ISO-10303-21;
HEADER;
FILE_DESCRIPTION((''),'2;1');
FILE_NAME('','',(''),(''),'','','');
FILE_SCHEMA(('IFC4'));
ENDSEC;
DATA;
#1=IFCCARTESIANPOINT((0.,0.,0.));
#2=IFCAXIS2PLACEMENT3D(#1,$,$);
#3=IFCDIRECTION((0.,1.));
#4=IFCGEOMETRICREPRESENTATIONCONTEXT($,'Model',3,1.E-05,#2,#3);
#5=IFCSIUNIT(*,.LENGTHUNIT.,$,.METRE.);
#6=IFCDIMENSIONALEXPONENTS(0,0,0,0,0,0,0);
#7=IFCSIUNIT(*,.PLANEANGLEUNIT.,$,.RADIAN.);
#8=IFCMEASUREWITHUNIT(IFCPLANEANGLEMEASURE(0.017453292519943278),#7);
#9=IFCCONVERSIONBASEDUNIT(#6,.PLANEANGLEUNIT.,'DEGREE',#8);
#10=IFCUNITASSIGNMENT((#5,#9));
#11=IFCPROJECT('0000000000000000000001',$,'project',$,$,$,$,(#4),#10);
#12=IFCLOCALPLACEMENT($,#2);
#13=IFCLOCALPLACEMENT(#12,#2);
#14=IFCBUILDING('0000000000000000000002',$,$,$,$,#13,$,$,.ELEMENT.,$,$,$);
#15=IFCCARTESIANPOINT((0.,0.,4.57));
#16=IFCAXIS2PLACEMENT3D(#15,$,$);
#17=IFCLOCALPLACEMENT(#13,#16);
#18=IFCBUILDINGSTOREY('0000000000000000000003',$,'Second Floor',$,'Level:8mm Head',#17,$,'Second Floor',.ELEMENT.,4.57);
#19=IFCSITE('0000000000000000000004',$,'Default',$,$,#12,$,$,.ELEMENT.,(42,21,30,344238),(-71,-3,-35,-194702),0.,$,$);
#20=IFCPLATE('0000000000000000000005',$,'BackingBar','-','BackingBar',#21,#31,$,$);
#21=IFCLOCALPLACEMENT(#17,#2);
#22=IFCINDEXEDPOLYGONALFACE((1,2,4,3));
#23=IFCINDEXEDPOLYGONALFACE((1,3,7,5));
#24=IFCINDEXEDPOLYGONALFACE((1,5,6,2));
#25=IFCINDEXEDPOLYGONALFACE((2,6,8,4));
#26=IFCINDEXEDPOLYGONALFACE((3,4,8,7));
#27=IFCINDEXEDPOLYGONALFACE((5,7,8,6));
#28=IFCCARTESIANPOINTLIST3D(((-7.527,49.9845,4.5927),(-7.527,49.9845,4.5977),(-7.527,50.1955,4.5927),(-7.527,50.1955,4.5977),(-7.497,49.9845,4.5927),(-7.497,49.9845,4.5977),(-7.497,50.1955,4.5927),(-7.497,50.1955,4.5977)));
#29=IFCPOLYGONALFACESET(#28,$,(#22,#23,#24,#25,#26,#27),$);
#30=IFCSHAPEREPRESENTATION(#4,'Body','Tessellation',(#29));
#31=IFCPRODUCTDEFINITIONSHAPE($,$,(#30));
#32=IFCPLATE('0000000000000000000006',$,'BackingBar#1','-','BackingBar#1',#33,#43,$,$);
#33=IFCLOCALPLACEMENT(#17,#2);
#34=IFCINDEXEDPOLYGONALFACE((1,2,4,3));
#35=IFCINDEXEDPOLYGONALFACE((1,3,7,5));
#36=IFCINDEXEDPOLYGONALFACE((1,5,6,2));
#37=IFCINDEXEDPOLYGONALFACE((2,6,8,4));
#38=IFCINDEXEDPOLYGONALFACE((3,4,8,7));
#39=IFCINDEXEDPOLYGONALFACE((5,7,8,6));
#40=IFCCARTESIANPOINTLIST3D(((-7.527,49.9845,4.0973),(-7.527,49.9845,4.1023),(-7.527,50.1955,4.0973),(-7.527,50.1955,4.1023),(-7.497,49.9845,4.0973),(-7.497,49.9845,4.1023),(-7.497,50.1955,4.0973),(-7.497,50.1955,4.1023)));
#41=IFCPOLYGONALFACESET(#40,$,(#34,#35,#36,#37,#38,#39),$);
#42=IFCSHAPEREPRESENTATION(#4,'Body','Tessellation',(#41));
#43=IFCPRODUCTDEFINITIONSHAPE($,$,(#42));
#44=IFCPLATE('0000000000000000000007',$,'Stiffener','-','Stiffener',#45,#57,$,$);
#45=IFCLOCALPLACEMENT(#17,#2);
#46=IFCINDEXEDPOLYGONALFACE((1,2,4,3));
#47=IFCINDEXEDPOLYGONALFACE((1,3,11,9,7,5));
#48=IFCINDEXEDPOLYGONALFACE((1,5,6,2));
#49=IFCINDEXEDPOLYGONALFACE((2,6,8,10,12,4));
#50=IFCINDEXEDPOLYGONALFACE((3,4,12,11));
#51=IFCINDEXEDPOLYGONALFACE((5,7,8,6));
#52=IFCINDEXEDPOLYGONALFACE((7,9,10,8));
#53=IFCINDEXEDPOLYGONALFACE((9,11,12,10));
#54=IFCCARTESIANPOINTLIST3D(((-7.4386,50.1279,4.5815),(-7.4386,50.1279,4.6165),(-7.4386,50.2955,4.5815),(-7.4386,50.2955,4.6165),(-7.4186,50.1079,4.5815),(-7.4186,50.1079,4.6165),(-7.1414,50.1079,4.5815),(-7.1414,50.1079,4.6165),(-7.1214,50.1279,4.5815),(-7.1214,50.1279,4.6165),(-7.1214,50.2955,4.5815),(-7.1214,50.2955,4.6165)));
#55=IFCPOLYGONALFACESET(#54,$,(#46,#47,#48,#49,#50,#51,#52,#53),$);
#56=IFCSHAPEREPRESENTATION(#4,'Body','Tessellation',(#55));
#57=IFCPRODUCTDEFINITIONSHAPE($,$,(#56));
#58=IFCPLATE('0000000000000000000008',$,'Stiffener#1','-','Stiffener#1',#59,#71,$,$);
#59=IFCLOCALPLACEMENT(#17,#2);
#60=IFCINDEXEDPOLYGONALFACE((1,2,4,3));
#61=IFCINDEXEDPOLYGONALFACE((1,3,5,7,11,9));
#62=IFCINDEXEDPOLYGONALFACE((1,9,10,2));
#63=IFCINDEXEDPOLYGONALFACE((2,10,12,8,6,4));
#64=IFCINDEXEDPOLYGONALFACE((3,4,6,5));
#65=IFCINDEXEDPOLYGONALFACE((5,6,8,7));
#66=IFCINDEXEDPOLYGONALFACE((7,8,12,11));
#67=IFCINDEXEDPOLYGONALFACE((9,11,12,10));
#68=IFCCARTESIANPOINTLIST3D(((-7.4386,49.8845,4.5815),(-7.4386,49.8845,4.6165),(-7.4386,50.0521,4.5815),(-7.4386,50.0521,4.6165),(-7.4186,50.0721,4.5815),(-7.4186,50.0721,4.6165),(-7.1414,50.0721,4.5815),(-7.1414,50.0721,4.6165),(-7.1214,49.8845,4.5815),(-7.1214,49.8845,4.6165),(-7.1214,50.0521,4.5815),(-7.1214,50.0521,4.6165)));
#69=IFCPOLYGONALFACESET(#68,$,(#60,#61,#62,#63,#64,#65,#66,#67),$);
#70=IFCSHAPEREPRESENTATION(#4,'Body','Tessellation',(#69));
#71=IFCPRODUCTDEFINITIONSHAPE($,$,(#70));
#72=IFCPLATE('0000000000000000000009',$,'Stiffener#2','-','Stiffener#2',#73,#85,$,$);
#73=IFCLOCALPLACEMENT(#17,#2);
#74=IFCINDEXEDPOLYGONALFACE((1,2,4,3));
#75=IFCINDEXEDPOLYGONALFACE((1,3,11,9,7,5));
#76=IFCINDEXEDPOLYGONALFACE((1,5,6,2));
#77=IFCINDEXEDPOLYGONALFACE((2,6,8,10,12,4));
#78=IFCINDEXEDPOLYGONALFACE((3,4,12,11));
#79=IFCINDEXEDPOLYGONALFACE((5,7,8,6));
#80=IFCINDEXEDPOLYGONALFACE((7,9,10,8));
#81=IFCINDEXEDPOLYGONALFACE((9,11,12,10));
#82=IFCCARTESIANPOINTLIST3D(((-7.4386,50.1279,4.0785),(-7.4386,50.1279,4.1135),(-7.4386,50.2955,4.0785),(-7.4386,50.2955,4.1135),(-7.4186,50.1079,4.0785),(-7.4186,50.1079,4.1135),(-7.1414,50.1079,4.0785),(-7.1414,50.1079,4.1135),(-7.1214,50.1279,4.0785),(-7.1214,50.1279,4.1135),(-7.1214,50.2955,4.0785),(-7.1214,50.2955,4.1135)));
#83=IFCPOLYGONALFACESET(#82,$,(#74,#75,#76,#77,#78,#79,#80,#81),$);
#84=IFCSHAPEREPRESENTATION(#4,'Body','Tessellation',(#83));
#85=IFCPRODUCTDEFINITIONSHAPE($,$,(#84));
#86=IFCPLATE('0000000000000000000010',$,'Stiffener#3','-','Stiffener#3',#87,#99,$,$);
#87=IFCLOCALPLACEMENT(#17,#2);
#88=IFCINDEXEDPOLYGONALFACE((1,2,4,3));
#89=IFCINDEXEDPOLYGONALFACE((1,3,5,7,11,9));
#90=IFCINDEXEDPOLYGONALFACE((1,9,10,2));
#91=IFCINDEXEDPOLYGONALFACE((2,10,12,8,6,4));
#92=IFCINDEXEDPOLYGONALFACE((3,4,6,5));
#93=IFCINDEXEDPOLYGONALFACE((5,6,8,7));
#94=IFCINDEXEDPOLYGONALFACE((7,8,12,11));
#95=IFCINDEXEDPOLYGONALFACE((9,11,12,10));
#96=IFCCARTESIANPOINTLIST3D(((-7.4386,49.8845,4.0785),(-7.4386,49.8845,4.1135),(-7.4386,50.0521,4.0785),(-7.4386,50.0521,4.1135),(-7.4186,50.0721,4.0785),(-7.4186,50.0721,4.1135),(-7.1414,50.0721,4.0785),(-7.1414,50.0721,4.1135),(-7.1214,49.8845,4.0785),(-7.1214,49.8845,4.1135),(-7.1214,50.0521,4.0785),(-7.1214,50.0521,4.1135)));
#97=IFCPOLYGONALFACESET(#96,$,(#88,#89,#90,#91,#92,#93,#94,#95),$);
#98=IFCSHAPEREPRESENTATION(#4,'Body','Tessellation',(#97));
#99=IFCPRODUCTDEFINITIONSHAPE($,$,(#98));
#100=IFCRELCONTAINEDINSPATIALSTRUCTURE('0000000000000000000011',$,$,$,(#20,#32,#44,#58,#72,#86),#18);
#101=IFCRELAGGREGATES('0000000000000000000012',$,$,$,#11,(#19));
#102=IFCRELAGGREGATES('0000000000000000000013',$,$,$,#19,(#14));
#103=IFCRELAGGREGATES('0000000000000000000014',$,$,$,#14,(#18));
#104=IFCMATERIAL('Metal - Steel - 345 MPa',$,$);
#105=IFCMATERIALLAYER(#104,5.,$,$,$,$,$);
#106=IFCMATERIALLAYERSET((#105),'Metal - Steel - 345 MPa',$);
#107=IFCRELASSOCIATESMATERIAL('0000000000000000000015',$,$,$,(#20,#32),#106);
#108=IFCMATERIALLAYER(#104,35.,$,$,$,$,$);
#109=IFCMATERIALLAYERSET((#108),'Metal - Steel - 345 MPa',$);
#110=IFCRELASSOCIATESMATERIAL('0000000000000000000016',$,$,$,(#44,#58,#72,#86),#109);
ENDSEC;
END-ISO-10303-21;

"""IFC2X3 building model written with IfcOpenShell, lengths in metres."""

from ifc_helpers import new_model, entity, si_unit, converted_unit, direction, frame, origin, origin_with_axes, place, context, project, spatial, polyline, outline, extrude, material, layer, layer_set, element, save


model = new_model("IFC2X3")

# Units and contexts
model_context = context("Model", 3, precision=1e-05, world=origin(), true_north=direction((0.0, 1.0)))
ifc_project = project(units=[si_unit("LENGTHUNIT", "METRE"), converted_unit("PLANEANGLEUNIT", "DEGREE", entity("IfcPlaneAngleMeasure", 0.017453292519943278), si_unit("PLANEANGLEUNIT", "RADIAN"), dimensions=[0, 0, 0, 0, 0, 0, 0])], contexts=[model_context])

# Site, building, storey
site_placement = place(None, origin())
site = spatial("IfcSite", under=ifc_project, at=site_placement, Name="Default", CompositionType="ELEMENT", RefLatitude=(42, 21, 30, 344238), RefLongitude=(-71, -3, -35, -194702), RefElevation=0.0)
building_placement = place(site_placement, origin())
building = spatial("IfcBuilding", under=site, at=building_placement, CompositionType="ELEMENT")
storey_placement = place(building_placement, frame((0.0, 0.0, 4.57)))
storey = spatial("IfcBuildingStorey", under=building, at=storey_placement, Name="Second Floor", ObjectType="Level:8mm Head", LongName="Second Floor", CompositionType="ELEMENT", Elevation=4.57)

# Plates
ifc_material_1 = material(Name="Metal - Steel - 345 MPa")
ifc_layer_1 = layer(ifc_material_1, 5.0)
ifc_layer_set_1 = layer_set([ifc_layer_1], Name="Metal - Steel - 345 MPa")
plate_1_placement = place(storey_placement, frame((-7.497, 49.9845, 4.5927), z_axis=(0.0, 0.0, 1.0), x_axis=(0.0, 1.0, 0.0)))
element("IfcPlate", 1, at=plate_1_placement, inside=storey, material=ifc_layer_set_1, Name="BackingBar", Description="-", ObjectType="BackingBar", context=model_context, shape_type="SweptSolid", body=[
    extrude(outline(polyline([(0.0, 0.0), (0.211, 0.0), (0.211, 0.03), (0.0, 0.03), (0.0, 0.0)])), origin_with_axes(), (0.0, 0.0, 1.0), 0.005),
])
plate_2_placement = place(storey_placement, frame((-7.497, 50.1955, 4.1023), z_axis=(0.0, 0.0, -1.0), x_axis=(0.0, -1.0, 0.0)))
element("IfcPlate", 2, at=plate_2_placement, inside=storey, material=ifc_layer_set_1, Name="BackingBar#1", Description="-", ObjectType="BackingBar#1", context=model_context, shape_type="SweptSolid", body=[
    extrude(outline(polyline([(0.0, 0.0), (0.211, 0.0), (0.211, 0.03), (0.0, 0.03), (0.0, 0.0)])), origin_with_axes(), (0.0, 0.0, 1.0), 0.005),
])

# Plates, openings
ifc_layer_2 = layer(ifc_material_1, 35.0)
ifc_layer_set_2 = layer_set([ifc_layer_2], Name="Metal - Steel - 345 MPa")
plate_3_placement = place(storey_placement, frame((-7.4386, 50.2955, 4.5815), z_axis=(0.0, 0.0, 1.0), x_axis=(0.0, -1.0, 0.0)))
plate_3 = element("IfcPlate", 3, at=plate_3_placement, inside=storey, material=ifc_layer_set_2, Name="Stiffener", Description="-", ObjectType="Stiffener", context=model_context, shape_type="SweptSolid", body=[
    extrude(outline(polyline([(0.0, 0.0), (0.1876, 0.0), (0.1876, 0.3172), (0.0, 0.3172), (0.0, 0.0)])), origin_with_axes(), (0.0, 0.0, 1.0), 0.035),
])
opening_1_placement = place(plate_3_placement, frame((0.0, 0.0, 0.0), z_axis=(0.0, 0.0, 1.0), x_axis=(1.0, 0.0, 0.0)))
element("IfcOpeningElement", 4, at=opening_1_placement, cuts=plate_3, ObjectType="Opening", context=model_context, shape_type="SweptSolid", body=[
    extrude(outline(polyline([(0.1876, 0.3172), (0.1676, 0.3172), (0.1876, 0.2972), (0.1876, 0.3172)])), origin(), (0.0, 0.0, 1.0), 0.035),
])
opening_2_placement = place(plate_3_placement, frame((0.0, 0.0, 0.0), z_axis=(0.0, 0.0, 1.0), x_axis=(1.0, 0.0, 0.0)))
element("IfcOpeningElement", 5, at=opening_2_placement, cuts=plate_3, ObjectType="Opening", context=model_context, shape_type="SweptSolid", body=[
    extrude(outline(polyline([(0.1876, 0.0), (0.1876, 0.02), (0.1676, 0.0), (0.1876, 0.0)])), origin(), (0.0, 0.0, 1.0), 0.035),
])
plate_4_placement = place(storey_placement, frame((-7.4386, 50.0721, 4.5815), z_axis=(0.0, 0.0, 1.0), x_axis=(0.0, -1.0, 0.0)))
plate_4 = element("IfcPlate", 6, at=plate_4_placement, inside=storey, material=ifc_layer_set_2, Name="Stiffener#1", Description="-", ObjectType="Stiffener#1", context=model_context, shape_type="SweptSolid", body=[
    extrude(outline(polyline([(0.0, 0.0), (0.1876, 0.0), (0.1876, 0.3172), (0.0, 0.3172), (0.0, 0.0)])), origin_with_axes(), (0.0, 0.0, 1.0), 0.035),
])
opening_3_placement = place(plate_4_placement, frame((0.0, 0.0, 0.0), z_axis=(0.0, 0.0, 1.0), x_axis=(1.0, 0.0, 0.0)))
element("IfcOpeningElement", 7, at=opening_3_placement, cuts=plate_4, ObjectType="Opening", context=model_context, shape_type="SweptSolid", body=[
    extrude(outline(polyline([(0.0, 0.3172), (0.0, 0.2972), (0.02, 0.3172), (0.0, 0.3172)])), origin(), (0.0, 0.0, 1.0), 0.035),
])
opening_4_placement = place(plate_4_placement, frame((0.0, 0.0, 0.0), z_axis=(0.0, 0.0, 1.0), x_axis=(1.0, 0.0, 0.0)))
element("IfcOpeningElement", 8, at=opening_4_placement, cuts=plate_4, ObjectType="Opening", context=model_context, shape_type="SweptSolid", body=[
    extrude(outline(polyline([(0.0, 0.0), (0.02, 0.0), (0.0, 0.02), (0.0, 0.0)])), origin(), (0.0, 0.0, 1.0), 0.035),
])
plate_5_placement = place(storey_placement, frame((-7.4386, 50.1079, 4.1135), z_axis=(0.0, 0.0, -1.0), x_axis=(0.0, 1.0, 0.0)))
plate_5 = element("IfcPlate", 9, at=plate_5_placement, inside=storey, material=ifc_layer_set_2, Name="Stiffener#2", Description="-", ObjectType="Stiffener#2", context=model_context, shape_type="SweptSolid", body=[
    extrude(outline(polyline([(0.0, 0.0), (0.1876, 0.0), (0.1876, 0.3172), (0.0, 0.3172), (0.0, 0.0)])), origin_with_axes(), (0.0, 0.0, 1.0), 0.035),
])
opening_5_placement = place(plate_5_placement, frame((0.0, 0.0, 0.0), z_axis=(0.0, 0.0, 1.0), x_axis=(1.0, 0.0, 0.0)))
element("IfcOpeningElement", 10, at=opening_5_placement, cuts=plate_5, ObjectType="Opening", context=model_context, shape_type="SweptSolid", body=[
    extrude(outline(polyline([(0.0, 0.3172), (0.0, 0.2972), (0.02, 0.3172), (0.0, 0.3172)])), origin(), (0.0, 0.0, 1.0), 0.035),
])
opening_6_placement = place(plate_5_placement, frame((0.0, 0.0, 0.0), z_axis=(0.0, 0.0, 1.0), x_axis=(1.0, 0.0, 0.0)))
element("IfcOpeningElement", 11, at=opening_6_placement, cuts=plate_5, ObjectType="Opening", context=model_context, shape_type="SweptSolid", body=[
    extrude(outline(polyline([(0.0, 0.0), (0.02, 0.0), (0.0, 0.02), (0.0, 0.0)])), origin(), (0.0, 0.0, 1.0), 0.035),
])
plate_6_placement = place(storey_placement, frame((-7.4386, 49.8845, 4.1135), z_axis=(0.0, 0.0, -1.0), x_axis=(0.0, 1.0, 0.0)))
plate_6 = element("IfcPlate", 12, at=plate_6_placement, inside=storey, material=ifc_layer_set_2, Name="Stiffener#3", Description="-", ObjectType="Stiffener#3", context=model_context, shape_type="SweptSolid", body=[
    extrude(outline(polyline([(0.0, 0.0), (0.1876, 0.0), (0.1876, 0.3172), (0.0, 0.3172), (0.0, 0.0)])), origin_with_axes(), (0.0, 0.0, 1.0), 0.035),
])
opening_7_placement = place(plate_6_placement, frame((0.0, 0.0, 0.0), z_axis=(0.0, 0.0, 1.0), x_axis=(1.0, 0.0, 0.0)))
element("IfcOpeningElement", 13, at=opening_7_placement, cuts=plate_6, ObjectType="Opening", context=model_context, shape_type="SweptSolid", body=[
    extrude(outline(polyline([(0.1876, 0.3172), (0.1676, 0.3172), (0.1876, 0.2972), (0.1876, 0.3172)])), origin(), (0.0, 0.0, 1.0), 0.035),
])
opening_8_placement = place(plate_6_placement, frame((0.0, 0.0, 0.0), z_axis=(0.0, 0.0, 1.0), x_axis=(1.0, 0.0, 0.0)))
element("IfcOpeningElement", 14, at=opening_8_placement, cuts=plate_6, ObjectType="Opening", context=model_context, shape_type="SweptSolid", body=[
    extrude(outline(polyline([(0.1876, 0.0), (0.1876, 0.02), (0.1676, 0.0), (0.1876, 0.0)])), origin(), (0.0, 0.0, 1.0), 0.035),
])

save(model, "model.ifc")
